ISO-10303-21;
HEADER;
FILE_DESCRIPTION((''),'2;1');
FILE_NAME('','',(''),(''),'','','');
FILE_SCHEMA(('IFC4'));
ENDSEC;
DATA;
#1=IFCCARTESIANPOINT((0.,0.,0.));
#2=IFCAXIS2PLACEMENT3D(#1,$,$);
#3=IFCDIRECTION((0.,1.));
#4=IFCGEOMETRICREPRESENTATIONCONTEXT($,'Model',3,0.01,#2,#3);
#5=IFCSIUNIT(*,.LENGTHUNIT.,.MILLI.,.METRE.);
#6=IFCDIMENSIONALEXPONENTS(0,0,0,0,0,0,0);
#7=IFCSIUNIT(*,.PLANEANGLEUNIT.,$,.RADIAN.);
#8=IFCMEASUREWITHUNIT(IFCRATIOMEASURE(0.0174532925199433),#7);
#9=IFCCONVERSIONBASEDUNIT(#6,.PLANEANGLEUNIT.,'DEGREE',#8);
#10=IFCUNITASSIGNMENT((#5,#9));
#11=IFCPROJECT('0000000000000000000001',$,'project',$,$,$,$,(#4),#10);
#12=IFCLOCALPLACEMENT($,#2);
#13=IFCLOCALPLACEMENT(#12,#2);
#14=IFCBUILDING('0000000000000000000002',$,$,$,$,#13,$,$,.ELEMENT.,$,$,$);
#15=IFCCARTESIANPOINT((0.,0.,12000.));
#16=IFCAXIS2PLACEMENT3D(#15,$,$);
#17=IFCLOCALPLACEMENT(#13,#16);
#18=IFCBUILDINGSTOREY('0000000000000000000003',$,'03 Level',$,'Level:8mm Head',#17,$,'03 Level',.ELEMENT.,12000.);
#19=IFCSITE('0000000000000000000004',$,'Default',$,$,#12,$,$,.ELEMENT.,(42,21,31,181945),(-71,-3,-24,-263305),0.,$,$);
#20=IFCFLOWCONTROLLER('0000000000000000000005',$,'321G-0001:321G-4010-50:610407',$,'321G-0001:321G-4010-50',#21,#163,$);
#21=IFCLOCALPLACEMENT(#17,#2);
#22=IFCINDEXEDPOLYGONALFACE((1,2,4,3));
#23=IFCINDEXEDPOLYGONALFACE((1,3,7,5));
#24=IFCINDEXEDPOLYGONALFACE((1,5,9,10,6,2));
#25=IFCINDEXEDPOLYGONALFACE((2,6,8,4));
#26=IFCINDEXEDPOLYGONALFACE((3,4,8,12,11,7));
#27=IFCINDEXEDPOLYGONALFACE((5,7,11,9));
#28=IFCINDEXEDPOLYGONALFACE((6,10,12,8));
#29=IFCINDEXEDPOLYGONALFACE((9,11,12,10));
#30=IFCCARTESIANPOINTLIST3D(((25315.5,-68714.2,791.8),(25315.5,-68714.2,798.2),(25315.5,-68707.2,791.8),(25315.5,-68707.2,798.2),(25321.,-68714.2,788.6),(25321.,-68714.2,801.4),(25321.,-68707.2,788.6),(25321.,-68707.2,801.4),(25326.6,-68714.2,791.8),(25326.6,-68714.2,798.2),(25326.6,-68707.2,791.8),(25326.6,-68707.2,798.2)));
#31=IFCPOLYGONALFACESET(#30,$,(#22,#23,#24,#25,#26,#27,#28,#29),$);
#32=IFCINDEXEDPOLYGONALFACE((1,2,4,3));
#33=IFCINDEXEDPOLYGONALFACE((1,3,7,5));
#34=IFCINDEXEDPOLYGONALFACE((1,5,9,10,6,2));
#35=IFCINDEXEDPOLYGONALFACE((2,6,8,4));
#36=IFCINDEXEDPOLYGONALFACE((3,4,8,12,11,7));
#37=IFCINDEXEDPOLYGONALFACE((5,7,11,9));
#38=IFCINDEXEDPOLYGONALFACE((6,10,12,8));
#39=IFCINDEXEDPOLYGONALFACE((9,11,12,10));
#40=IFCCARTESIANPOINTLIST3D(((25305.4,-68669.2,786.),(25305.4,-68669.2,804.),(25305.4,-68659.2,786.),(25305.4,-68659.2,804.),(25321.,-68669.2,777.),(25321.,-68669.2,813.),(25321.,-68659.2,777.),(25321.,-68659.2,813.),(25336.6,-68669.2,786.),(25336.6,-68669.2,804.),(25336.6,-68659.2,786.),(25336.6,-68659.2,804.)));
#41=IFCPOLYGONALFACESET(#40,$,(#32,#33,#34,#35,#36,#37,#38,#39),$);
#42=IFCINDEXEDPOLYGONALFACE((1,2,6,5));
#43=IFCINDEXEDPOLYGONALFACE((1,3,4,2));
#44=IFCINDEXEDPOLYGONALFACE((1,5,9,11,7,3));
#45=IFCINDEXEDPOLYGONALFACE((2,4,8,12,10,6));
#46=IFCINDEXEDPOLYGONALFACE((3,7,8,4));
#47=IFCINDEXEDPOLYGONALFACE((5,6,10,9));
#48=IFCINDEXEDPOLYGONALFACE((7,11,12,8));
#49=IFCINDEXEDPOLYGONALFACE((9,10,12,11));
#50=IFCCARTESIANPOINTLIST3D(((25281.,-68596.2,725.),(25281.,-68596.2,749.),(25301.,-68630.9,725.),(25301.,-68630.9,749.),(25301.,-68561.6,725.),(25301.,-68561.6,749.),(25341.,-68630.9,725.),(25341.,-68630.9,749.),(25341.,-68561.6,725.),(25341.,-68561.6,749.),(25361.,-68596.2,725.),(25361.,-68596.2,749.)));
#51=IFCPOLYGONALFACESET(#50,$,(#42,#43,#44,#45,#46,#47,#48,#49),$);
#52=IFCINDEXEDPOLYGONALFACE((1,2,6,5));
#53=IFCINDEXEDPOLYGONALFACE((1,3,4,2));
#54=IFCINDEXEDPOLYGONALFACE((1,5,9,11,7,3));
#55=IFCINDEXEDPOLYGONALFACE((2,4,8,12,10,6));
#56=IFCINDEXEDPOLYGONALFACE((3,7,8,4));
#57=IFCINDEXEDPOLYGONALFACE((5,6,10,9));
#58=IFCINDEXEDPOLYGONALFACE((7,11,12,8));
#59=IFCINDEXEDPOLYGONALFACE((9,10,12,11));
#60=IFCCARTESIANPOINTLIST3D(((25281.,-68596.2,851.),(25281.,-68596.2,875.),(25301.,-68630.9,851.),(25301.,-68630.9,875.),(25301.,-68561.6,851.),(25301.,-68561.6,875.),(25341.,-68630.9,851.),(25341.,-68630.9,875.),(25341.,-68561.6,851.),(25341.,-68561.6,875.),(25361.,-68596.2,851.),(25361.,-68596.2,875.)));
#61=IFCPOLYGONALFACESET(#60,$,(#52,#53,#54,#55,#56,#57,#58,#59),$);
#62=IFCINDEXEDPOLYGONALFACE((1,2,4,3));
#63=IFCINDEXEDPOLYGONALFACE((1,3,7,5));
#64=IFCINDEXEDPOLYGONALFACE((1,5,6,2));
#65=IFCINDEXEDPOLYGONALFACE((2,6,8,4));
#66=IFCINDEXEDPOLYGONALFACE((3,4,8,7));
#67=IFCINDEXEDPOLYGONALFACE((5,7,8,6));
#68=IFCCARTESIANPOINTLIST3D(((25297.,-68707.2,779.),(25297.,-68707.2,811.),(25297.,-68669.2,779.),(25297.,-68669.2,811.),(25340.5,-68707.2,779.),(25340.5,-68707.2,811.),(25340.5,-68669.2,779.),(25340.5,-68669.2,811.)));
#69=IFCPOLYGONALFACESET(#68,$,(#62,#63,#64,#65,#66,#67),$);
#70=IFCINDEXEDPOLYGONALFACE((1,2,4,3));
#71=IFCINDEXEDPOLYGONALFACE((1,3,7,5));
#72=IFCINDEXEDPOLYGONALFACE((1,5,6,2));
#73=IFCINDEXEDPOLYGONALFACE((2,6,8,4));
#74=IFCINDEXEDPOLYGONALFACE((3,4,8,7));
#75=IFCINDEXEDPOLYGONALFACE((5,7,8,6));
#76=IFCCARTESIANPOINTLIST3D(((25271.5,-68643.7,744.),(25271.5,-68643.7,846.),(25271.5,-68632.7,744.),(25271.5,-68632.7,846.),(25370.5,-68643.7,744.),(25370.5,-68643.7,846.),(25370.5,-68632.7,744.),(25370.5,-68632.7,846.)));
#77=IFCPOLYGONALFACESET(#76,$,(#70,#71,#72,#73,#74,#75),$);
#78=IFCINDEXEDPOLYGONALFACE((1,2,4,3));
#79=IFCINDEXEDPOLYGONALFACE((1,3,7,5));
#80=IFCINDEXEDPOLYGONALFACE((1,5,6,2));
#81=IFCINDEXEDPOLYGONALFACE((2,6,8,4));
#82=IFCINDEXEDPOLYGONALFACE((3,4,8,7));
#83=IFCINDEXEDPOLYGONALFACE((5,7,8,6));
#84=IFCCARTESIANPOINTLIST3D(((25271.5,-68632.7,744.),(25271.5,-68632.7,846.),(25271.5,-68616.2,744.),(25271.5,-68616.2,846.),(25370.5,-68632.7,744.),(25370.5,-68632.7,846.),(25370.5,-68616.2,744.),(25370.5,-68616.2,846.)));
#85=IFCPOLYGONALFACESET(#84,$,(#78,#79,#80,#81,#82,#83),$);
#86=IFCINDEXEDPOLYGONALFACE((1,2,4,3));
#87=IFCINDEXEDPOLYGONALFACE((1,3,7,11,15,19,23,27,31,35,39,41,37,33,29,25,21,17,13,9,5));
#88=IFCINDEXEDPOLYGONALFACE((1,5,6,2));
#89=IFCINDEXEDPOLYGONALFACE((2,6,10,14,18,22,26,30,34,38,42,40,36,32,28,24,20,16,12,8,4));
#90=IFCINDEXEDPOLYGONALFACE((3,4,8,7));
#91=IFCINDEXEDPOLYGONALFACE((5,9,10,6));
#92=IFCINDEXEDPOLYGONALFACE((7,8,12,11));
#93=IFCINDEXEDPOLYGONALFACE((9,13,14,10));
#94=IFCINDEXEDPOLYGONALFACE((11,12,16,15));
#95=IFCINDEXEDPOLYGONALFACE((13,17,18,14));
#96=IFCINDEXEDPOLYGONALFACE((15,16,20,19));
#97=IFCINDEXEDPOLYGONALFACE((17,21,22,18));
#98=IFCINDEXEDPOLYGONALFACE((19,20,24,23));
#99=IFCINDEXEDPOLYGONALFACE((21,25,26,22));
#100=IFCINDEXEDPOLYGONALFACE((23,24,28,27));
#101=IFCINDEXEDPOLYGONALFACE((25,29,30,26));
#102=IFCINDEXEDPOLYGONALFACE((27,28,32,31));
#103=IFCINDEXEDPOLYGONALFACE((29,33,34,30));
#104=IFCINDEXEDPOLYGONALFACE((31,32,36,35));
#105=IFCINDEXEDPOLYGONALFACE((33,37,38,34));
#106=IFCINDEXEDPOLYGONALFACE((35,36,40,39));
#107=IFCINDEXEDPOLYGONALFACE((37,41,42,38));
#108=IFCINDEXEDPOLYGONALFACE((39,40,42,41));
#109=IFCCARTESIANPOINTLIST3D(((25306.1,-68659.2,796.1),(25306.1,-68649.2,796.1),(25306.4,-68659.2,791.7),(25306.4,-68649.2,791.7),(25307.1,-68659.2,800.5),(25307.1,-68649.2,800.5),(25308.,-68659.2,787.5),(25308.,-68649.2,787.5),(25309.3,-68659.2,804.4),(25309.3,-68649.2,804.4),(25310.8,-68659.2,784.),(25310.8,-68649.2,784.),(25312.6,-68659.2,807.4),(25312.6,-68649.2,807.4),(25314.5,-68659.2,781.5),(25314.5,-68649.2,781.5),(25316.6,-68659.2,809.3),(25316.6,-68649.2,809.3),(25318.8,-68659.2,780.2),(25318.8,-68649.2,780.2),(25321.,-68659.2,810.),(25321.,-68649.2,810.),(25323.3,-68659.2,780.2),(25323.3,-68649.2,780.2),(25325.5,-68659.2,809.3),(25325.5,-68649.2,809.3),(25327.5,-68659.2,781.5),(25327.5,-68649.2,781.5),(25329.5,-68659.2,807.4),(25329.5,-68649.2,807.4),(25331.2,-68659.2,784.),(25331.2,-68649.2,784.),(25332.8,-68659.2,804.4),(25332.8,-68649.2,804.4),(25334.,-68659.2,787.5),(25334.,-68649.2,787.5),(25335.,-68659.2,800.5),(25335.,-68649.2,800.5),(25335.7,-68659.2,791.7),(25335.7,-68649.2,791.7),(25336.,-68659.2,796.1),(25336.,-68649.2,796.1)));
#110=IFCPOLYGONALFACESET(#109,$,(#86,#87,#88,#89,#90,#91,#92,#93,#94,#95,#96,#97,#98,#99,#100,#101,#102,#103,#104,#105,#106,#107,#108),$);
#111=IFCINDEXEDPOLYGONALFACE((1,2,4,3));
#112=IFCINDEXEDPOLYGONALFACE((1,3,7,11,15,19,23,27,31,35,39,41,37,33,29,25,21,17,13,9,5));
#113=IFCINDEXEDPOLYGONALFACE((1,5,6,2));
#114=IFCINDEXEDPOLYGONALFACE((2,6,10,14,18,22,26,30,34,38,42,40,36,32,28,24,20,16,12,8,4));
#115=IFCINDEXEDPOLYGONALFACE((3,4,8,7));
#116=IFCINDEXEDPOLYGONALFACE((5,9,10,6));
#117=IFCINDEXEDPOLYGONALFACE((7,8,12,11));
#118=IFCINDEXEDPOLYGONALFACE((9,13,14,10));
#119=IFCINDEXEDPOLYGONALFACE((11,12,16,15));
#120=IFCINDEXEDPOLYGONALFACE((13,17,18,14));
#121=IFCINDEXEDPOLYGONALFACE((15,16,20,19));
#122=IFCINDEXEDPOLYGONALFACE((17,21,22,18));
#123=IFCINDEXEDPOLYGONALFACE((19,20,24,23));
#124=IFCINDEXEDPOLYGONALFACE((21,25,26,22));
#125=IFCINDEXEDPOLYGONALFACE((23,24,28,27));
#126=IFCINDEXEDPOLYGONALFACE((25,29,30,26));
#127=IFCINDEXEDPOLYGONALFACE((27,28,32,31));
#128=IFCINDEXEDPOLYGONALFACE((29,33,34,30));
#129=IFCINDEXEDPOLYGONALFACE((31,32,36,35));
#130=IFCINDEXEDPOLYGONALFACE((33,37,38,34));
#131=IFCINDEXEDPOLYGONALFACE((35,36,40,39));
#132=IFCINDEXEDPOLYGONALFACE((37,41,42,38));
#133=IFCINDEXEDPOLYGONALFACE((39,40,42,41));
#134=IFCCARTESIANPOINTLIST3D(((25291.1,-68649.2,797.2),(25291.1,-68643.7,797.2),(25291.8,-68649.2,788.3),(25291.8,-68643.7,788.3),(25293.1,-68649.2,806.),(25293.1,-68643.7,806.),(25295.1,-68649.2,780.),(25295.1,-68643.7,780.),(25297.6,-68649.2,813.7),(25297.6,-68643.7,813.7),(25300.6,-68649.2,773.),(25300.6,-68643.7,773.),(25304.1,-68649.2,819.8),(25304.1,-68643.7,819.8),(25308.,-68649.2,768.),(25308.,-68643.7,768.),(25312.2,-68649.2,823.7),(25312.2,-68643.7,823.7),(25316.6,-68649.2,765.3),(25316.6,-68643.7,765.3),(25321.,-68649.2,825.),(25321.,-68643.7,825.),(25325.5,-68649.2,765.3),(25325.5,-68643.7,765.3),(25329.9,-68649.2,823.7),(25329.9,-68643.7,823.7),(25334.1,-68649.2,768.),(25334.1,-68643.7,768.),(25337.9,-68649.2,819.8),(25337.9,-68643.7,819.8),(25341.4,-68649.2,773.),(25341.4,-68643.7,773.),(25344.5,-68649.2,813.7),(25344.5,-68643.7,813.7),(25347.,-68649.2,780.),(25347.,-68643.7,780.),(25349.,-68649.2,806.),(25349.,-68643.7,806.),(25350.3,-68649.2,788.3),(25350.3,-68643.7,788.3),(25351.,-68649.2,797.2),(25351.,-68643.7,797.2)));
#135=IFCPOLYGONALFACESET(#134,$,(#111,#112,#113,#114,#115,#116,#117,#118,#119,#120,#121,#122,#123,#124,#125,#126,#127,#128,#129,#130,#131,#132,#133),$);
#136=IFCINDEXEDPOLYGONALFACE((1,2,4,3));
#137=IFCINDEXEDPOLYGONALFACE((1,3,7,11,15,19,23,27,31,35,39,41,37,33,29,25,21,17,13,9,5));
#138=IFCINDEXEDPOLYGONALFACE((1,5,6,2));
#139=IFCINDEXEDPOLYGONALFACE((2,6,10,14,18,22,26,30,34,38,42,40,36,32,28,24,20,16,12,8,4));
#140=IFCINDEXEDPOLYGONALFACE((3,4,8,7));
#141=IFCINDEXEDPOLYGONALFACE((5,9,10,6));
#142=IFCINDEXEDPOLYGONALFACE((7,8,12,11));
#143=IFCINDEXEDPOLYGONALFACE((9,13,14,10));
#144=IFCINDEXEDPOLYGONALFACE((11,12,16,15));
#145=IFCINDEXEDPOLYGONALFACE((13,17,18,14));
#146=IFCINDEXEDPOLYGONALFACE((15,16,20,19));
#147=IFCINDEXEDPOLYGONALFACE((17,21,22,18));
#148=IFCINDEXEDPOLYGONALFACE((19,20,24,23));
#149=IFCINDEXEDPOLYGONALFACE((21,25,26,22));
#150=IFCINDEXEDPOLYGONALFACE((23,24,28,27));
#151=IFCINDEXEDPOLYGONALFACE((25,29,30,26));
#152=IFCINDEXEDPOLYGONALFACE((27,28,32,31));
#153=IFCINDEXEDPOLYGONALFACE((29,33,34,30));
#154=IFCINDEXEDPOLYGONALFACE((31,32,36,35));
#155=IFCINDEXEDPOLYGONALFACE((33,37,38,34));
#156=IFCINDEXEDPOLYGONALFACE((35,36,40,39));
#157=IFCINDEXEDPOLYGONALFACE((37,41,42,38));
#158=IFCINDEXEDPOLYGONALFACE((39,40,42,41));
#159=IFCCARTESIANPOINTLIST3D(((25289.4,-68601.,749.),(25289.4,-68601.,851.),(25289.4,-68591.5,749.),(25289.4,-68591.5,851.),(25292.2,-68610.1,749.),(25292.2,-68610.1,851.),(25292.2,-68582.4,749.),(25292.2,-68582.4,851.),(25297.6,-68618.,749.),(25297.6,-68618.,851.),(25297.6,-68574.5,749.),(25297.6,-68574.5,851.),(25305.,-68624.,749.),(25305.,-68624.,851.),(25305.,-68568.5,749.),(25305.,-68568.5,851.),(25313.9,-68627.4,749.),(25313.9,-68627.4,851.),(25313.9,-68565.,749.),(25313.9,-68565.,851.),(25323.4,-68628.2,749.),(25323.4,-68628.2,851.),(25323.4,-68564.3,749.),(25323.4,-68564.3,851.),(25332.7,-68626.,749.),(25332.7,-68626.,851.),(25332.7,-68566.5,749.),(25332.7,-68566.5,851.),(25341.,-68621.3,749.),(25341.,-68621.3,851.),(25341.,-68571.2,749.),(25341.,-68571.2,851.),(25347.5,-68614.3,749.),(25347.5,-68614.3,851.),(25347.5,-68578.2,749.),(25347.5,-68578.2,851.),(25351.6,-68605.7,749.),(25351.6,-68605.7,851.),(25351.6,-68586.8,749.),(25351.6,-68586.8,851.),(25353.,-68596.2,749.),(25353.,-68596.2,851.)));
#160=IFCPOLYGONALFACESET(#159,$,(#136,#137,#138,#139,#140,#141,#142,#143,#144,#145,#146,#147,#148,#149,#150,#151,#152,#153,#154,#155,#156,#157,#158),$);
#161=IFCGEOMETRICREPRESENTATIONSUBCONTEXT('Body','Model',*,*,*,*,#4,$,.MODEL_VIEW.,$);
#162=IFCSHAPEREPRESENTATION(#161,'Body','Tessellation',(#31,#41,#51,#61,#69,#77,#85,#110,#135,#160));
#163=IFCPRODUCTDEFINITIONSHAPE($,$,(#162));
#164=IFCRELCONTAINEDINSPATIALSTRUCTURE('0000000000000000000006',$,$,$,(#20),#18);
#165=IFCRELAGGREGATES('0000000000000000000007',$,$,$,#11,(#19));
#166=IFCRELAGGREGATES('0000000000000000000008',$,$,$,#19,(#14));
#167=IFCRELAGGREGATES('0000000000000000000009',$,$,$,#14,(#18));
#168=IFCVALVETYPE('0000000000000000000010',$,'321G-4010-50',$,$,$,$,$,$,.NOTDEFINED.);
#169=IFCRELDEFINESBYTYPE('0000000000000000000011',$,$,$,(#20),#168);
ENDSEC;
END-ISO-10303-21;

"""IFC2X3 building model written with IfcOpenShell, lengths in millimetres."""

from ifc_helpers import new_model, entity, si_unit, converted_unit, direction, frame, frame_2d, origin, origin_2d_with_axis, place, context, subcontext, project, spatial, polyline, rectangle, circle, outline, extrude, source, transform, mapped, type_object, type_shapes, element, save


model = new_model("IFC2X3")

# Units and contexts
model_context = context("Model", 3, precision=0.01, world=origin(), true_north=direction((0.0, 1.0)))
body_context = subcontext(model_context, "Body", "Model", "MODEL_VIEW")
ifc_project = project(units=[si_unit("LENGTHUNIT", "METRE", prefix="MILLI"), converted_unit("PLANEANGLEUNIT", "DEGREE", entity("IfcRatioMeasure", 0.0174532925199433), si_unit("PLANEANGLEUNIT", "RADIAN"), dimensions=[0, 0, 0, 0, 0, 0, 0])], contexts=[model_context])

# Site, building, storey
site_placement = place(None, origin())
site = spatial("IfcSite", under=ifc_project, at=site_placement, Name="Default", CompositionType="ELEMENT", RefLatitude=(42, 21, 31, 181945), RefLongitude=(-71, -3, -24, -263305), RefElevation=0.0)
building_placement = place(site_placement, origin())
building = spatial("IfcBuilding", under=site, at=building_placement, CompositionType="ELEMENT")
storey_placement = place(building_placement, frame((0.0, 0.0, 12000.0)))
storey = spatial("IfcBuildingStorey", under=building, at=storey_placement, Name="03 Level", ObjectType="Level:8mm Head", LongName="03 Level", CompositionType="ELEMENT", Elevation=12000.0)

# Flow controller
valve_type_1 = type_object("IfcValveType", Name="321G-4010-50", PredefinedType="NOTDEFINED")
shared_shape_1 = source(origin(), body_context, "Body", "SweptSolid", [
    extrude(outline(polyline([(-3.2, -5.5), (3.2, -5.5), (6.4, 0.0), (3.2, 5.5), (-3.2, 5.5), (-6.4, 0.0), (-3.2, -5.5)])), frame((-5.0, 0.0, 111.0), z_axis=(0.0, 0.0, 1.0), x_axis=(0.5, 0.866025, 0.0)), (0.0, 0.0, 1.0), 7.0),
    extrude(outline(polyline([(-9.0, -15.6), (9.0, -15.6), (18.0, 0.0), (9.0, 15.6), (-9.0, 15.6), (-18.0, 0.0), (-9.0, -15.6)])), frame((-5.0, 0.0, 63.0), z_axis=(0.0, 0.0, 1.0), x_axis=(0.5, 0.866025, 0.0)), (0.0, 0.0, 1.0), 10.0),
    extrude(outline(polyline([(-20.0, -34.6), (20.0, -34.6), (40.0, 0.0), (20.0, 34.6), (-20.0, 34.6), (-40.0, 0.0), (-20.0, -34.6)])), frame((-75.0, 0.0, 0.0), z_axis=(1.0, 0.0, 0.0), x_axis=(0.0, -0.5, -0.866025)), (0.0, 0.0, 1.0), 24.0),
    extrude(outline(polyline([(-20.0, -34.6), (20.0, -34.6), (40.0, 0.0), (20.0, 34.6), (-20.0, 34.6), (-40.0, 0.0), (-20.0, -34.6)])), frame((51.0, 0.0, 0.0), z_axis=(1.0, 0.0, 0.0), x_axis=(0.0, -0.5, -0.866025)), (0.0, 0.0, 1.0), 24.0),
    extrude(rectangle(XDim=43.5, YDim=32.0, at=frame_2d((0.0, 0.0), x_axis=(1.0, 0.0))), frame((-5.0, 2.2, 73.0), z_axis=(0.0, 0.0, 1.0), x_axis=(0.0, -1.0, 0.0)), (0.0, 0.0, 1.0), 38.0),
    extrude(rectangle(XDim=99.0, YDim=102.0, at=origin_2d_with_axis()), frame((-5.0, 0.0, 36.5), z_axis=(0.0, 0.0, 1.0), x_axis=(0.0, -1.0, 0.0)), (0.0, 0.0, 1.0), 11.0),
    extrude(rectangle(XDim=99.0, YDim=102.0, at=origin_2d_with_axis()), frame((-5.0, 0.0, 20.0), z_axis=(0.0, 0.0, 1.0), x_axis=(0.0, -1.0, 0.0)), (0.0, 0.0, 1.0), 16.5),
    extrude(circle(Radius=15.0, at=frame_2d((0.0, 0.0), x_axis=(1.0, 0.0))), frame((-5.0, 0.0, 53.0)), (0.0, 0.0, 1.0), 10.0),
    extrude(circle(Radius=30.0, at=frame_2d((0.0, 0.0), x_axis=(1.0, 0.0))), frame((-5.0, 0.0, 47.5)), (0.0, 0.0, 1.0), 5.5),
    extrude(circle(Radius=32.0, at=frame_2d((0.0, 0.0), x_axis=(1.0, 0.0))), frame((-51.0, 0.0, 0.0), z_axis=(1.0, 0.0, 0.0), x_axis=(0.0, -1.0, 0.0)), (0.0, 0.0, 1.0), 102.0),
])
type_shapes(valve_type_1, [shared_shape_1])
flow_controller_1_placement = place(storey_placement, frame((25321.0, -68596.2, 800.0), z_axis=(0.0, -1.0, 0.0), x_axis=(0.0, 0.0, 1.0)))
element("IfcFlowController", 1, at=flow_controller_1_placement, inside=storey, type_object=valve_type_1, Name="321G-0001:321G-4010-50:610407", ObjectType="321G-0001:321G-4010-50", context=body_context, shape_type="MappedRepresentation", body=[
    mapped(shared_shape_1, transform((0.0, 0.0, 0.0), scale=1.0)),
])

save(model, "model.ifc")
